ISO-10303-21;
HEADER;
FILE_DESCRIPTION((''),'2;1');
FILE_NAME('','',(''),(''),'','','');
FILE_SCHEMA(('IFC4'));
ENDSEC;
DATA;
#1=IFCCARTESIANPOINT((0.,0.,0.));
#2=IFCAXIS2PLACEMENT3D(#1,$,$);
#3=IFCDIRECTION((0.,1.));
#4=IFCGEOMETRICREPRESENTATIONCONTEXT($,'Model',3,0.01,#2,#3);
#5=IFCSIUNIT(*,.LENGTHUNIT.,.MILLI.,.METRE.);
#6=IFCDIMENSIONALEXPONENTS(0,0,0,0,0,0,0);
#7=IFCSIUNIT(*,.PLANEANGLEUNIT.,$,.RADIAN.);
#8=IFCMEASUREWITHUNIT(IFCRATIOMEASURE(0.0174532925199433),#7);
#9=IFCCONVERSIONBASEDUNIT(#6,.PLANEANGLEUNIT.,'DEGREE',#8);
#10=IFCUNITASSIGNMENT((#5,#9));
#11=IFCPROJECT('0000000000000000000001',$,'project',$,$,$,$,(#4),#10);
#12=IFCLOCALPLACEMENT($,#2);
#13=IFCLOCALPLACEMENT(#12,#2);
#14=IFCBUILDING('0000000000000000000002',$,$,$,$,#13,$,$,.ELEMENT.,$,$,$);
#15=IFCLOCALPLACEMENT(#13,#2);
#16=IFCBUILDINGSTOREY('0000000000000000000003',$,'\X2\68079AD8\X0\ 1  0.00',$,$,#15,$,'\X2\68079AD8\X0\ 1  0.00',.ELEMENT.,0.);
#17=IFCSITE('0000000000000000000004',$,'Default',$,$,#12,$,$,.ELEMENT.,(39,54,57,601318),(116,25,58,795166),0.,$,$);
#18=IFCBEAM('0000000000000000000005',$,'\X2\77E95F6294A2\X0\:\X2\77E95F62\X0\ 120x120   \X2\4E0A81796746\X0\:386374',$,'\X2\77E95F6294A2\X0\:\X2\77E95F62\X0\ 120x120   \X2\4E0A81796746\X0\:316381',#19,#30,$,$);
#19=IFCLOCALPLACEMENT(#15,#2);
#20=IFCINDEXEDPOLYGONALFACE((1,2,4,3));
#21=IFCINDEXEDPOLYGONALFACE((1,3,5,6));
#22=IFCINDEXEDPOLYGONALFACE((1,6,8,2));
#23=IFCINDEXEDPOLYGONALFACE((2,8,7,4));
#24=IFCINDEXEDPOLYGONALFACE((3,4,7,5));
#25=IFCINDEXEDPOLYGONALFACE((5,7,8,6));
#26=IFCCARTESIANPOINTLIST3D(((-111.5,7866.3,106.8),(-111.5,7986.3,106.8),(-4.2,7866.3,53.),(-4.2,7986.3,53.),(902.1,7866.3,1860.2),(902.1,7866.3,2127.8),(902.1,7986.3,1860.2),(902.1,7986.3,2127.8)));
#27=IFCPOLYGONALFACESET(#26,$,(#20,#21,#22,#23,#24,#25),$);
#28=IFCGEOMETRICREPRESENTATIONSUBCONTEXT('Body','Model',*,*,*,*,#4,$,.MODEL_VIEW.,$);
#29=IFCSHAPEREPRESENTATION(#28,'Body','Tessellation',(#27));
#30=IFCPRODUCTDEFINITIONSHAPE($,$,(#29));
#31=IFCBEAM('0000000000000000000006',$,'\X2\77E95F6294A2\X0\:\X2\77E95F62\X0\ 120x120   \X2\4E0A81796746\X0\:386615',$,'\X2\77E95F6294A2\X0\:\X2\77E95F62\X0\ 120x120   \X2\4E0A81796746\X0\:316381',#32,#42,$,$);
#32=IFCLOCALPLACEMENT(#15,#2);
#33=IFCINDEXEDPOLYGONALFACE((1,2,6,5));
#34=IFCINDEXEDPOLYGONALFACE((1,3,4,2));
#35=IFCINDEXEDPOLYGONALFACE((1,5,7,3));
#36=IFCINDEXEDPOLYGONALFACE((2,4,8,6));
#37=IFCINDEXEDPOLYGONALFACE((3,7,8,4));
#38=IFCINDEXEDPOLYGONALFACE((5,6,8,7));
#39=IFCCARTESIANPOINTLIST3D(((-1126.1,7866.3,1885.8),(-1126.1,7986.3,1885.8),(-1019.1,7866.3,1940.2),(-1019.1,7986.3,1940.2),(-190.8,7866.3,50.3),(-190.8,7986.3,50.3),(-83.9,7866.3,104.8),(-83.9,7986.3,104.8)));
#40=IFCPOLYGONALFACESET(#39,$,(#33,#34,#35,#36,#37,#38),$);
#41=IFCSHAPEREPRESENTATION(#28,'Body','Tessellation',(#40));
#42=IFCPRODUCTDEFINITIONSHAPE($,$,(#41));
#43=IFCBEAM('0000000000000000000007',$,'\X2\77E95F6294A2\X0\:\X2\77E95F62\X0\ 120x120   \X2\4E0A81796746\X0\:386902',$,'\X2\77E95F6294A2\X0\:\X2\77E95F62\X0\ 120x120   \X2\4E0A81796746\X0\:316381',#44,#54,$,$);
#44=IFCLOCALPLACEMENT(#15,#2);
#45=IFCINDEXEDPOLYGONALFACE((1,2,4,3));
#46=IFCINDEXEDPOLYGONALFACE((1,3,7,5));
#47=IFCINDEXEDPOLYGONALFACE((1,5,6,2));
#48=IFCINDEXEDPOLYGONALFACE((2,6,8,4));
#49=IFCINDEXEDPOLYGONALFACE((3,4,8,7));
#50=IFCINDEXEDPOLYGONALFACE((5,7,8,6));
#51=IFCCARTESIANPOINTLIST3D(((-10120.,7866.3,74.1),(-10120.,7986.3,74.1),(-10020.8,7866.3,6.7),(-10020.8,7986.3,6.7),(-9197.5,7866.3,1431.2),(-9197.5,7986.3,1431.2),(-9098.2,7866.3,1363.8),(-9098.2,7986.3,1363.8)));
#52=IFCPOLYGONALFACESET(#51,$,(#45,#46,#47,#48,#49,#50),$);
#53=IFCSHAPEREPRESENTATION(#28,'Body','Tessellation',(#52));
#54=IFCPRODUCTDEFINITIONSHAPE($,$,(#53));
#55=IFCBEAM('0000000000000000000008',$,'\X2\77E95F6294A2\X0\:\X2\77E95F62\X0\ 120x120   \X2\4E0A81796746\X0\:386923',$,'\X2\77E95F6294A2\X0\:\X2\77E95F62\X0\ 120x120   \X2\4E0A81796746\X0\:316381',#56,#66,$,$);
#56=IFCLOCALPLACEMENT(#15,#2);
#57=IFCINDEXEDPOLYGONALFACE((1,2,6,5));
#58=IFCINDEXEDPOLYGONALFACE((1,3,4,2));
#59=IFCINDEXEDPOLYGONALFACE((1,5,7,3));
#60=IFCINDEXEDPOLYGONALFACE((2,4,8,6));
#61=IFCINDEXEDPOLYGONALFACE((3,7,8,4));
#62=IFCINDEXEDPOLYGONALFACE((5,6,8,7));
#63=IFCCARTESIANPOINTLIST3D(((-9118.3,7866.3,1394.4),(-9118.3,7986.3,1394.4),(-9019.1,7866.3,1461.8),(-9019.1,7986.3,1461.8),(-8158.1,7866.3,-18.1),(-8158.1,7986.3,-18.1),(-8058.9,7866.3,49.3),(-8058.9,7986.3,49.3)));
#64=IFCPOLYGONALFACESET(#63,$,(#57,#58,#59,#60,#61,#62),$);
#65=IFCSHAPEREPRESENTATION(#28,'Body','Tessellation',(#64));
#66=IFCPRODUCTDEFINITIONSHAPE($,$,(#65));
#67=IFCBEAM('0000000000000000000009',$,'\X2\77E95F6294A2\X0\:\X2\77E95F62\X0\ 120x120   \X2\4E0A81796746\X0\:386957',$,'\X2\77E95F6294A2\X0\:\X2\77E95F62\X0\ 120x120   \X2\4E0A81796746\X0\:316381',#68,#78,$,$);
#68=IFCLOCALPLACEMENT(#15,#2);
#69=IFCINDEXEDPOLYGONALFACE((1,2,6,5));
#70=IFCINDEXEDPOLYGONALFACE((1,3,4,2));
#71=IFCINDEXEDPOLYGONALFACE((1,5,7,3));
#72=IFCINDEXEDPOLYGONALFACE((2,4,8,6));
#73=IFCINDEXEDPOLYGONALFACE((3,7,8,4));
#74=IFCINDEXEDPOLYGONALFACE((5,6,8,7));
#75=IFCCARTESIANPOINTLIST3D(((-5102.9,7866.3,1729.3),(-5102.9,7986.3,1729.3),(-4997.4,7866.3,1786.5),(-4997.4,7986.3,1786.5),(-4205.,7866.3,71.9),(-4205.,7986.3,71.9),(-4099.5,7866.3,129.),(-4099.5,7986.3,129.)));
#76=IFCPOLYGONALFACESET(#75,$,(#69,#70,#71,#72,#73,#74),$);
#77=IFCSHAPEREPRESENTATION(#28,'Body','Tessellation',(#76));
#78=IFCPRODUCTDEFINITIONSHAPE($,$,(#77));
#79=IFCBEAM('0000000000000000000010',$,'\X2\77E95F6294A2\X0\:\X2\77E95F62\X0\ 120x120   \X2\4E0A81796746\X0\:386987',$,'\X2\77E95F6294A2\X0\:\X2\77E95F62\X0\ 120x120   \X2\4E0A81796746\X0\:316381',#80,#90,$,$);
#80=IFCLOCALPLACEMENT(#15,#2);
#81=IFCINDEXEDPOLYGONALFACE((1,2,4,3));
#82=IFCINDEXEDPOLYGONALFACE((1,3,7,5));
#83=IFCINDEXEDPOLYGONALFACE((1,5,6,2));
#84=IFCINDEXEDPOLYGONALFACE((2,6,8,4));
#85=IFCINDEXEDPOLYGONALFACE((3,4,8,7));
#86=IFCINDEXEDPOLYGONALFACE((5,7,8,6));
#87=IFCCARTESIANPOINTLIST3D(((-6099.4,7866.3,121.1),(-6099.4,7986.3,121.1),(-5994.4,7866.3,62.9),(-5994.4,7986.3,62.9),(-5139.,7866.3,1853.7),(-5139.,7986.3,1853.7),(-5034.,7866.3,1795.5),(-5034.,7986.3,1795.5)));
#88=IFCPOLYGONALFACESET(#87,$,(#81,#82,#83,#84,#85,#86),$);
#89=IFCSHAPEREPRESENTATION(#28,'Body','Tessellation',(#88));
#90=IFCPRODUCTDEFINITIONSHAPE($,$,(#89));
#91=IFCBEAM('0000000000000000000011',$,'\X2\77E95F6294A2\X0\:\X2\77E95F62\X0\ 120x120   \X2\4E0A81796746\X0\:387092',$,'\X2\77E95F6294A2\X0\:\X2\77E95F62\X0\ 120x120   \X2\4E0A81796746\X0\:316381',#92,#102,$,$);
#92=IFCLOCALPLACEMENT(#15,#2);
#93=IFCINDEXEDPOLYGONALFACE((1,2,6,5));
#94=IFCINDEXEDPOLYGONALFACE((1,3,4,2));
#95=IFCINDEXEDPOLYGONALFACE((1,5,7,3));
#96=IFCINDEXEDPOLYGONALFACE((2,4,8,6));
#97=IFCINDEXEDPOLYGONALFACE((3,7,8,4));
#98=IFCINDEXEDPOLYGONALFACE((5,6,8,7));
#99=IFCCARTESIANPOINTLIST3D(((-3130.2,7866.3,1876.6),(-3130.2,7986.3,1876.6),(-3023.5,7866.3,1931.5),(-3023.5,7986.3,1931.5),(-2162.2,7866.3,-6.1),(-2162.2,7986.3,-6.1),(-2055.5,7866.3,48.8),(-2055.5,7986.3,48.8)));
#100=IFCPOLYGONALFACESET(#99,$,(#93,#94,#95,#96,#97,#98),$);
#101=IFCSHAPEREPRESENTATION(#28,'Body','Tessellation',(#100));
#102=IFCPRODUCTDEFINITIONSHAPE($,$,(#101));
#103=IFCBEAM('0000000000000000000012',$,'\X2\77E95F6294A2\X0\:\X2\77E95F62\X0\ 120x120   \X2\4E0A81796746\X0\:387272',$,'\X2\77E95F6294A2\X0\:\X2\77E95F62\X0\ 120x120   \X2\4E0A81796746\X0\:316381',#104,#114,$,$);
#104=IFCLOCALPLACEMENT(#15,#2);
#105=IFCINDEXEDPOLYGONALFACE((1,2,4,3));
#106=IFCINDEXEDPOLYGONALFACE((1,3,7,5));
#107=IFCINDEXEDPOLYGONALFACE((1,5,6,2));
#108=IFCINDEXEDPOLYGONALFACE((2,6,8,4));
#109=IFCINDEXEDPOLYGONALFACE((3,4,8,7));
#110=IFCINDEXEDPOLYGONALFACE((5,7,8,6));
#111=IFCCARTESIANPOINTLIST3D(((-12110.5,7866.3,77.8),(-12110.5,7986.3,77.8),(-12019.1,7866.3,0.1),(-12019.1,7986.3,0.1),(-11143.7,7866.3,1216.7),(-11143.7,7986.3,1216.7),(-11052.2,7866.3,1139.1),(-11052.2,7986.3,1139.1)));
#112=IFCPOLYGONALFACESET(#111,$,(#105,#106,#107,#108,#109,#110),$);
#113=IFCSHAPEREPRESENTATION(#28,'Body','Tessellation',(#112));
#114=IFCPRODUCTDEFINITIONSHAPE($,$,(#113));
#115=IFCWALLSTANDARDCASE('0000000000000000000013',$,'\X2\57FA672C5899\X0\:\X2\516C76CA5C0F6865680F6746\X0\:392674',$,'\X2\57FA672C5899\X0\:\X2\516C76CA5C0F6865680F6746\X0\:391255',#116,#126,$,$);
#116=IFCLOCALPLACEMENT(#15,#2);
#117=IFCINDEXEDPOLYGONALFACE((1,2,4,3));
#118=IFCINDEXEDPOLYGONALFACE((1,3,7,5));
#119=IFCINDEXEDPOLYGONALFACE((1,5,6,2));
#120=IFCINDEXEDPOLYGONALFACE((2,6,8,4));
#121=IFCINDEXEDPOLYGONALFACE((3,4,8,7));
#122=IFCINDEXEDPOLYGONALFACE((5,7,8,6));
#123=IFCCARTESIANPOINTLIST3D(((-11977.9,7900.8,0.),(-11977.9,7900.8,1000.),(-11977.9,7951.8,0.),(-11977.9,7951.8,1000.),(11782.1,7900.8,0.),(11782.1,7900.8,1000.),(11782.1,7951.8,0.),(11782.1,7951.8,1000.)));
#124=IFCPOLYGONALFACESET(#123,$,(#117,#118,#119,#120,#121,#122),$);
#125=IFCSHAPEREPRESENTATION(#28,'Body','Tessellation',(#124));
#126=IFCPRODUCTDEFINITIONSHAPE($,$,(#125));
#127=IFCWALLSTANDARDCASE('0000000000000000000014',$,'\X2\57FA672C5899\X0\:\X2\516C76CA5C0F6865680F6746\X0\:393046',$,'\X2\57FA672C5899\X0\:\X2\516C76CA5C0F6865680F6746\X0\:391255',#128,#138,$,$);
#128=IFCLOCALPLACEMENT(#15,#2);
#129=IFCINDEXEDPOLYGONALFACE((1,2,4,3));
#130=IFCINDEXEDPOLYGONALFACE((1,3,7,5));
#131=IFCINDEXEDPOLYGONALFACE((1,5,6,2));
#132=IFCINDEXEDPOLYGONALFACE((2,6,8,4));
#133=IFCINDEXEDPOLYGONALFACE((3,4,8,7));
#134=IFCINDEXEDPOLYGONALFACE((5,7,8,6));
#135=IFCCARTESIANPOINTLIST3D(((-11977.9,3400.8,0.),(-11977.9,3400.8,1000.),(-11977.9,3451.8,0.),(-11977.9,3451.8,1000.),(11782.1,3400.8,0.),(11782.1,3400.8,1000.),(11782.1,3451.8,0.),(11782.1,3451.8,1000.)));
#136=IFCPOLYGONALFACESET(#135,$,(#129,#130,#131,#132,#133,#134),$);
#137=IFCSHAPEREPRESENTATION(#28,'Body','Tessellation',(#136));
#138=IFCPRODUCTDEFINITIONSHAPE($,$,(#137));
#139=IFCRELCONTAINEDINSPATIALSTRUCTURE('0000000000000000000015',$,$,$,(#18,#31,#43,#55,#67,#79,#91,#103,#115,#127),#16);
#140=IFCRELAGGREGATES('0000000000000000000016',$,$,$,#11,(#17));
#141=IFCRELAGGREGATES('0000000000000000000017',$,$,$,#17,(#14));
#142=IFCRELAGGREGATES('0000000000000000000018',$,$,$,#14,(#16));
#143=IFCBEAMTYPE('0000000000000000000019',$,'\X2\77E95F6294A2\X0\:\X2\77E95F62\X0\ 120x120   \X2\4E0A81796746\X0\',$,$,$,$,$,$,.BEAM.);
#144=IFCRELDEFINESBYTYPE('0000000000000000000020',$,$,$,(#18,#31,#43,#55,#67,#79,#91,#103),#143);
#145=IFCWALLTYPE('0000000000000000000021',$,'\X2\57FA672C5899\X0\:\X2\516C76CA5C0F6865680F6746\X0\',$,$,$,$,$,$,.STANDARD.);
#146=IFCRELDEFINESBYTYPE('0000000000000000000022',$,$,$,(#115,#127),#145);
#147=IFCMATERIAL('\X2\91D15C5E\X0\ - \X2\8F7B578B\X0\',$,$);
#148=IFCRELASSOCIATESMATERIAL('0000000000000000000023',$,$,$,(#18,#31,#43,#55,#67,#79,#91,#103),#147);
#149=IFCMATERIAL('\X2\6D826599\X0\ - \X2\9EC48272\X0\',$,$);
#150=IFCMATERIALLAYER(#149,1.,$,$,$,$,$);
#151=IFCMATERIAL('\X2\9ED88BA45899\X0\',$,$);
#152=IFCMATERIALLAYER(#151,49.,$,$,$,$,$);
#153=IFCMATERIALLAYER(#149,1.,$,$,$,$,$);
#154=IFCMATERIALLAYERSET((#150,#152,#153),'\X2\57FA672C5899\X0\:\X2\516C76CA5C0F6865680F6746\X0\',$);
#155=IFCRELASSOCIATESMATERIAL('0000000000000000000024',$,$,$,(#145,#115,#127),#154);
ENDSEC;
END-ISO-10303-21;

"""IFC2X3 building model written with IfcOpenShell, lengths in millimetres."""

from ifc_helpers import new_model, entity, si_unit, converted_unit, direction, frame, frame_2d, origin, origin_2d_with_axis, place, context, subcontext, project, spatial, rectangle, extrude, clip, halfspace, material, layer, layer_set, layer_usage, type_object, element, save


model = new_model("IFC2X3")

# Units and contexts
model_context = context("Model", 3, precision=0.01, world=origin(), true_north=direction((0.0, 1.0)))
body_context = subcontext(model_context, "Body", "Model", "MODEL_VIEW")
ifc_project = project(units=[si_unit("LENGTHUNIT", "METRE", prefix="MILLI"), converted_unit("PLANEANGLEUNIT", "DEGREE", entity("IfcRatioMeasure", 0.0174532925199433), si_unit("PLANEANGLEUNIT", "RADIAN"), dimensions=[0, 0, 0, 0, 0, 0, 0])], contexts=[model_context])

# Site, building, storey
site_placement = place(None, origin())
site = spatial("IfcSite", under=ifc_project, at=site_placement, Name="Default", CompositionType="ELEMENT", RefLatitude=(39, 54, 57, 601318), RefLongitude=(116, 25, 58, 795166), RefElevation=0.0)
building_placement = place(site_placement, origin())
building = spatial("IfcBuilding", under=site, at=building_placement, CompositionType="ELEMENT")
storey_placement = place(building_placement, origin())
storey = spatial("IfcBuildingStorey", under=building, at=storey_placement, Name="标高 1  0.00", LongName="标高 1  0.00", CompositionType="ELEMENT", Elevation=0.0)

# Shared definitions
ifc_material_1 = material(Name="金属 - 轻型")

# Beams
beam_type_1 = type_object("IfcBeamType", Name="矩形钢:矩形 120x120   上腹杆", PredefinedType="BEAM")
beam_1_placement = place(storey_placement, frame((-97.9, 7926.3, 0.0), z_axis=(0.893889, 0.0, -0.448289), x_axis=(0.448289, 0.0, 0.893889)))
element("IfcBeam", 1, at=beam_1_placement, inside=storey, type_object=beam_type_1, material=ifc_material_1, Name="矩形钢:矩形 120x120   上腹杆:386374", ObjectType="矩形钢:矩形 120x120   上腹杆:316381", context=body_context, shape_type="Clipping", body=[
    clip(extrude(rectangle(XDim=120.0, YDim=120.0, at=frame_2d((0.0, 0.0), x_axis=(1.0, 0.0))), frame((89.4, 0.0, 0.0), z_axis=(1.0, 0.0, 0.0), x_axis=(0.0, 0.0, -1.0)), (0.0, 0.0, 1.0), 2261.0), halfspace(frame((2111.1, 0.0, 60.0), z_axis=(0.448289, 0.0, 0.893889), x_axis=(0.0, 1.0, 0.0)), False)),
])
beam_2_placement = place(storey_placement, frame((-97.9, 7926.3, 0.0), z_axis=(0.891007, 0.0, 0.45399), x_axis=(-0.45399, 0.0, 0.891007)))
element("IfcBeam", 2, at=beam_2_placement, inside=storey, type_object=beam_type_1, material=ifc_material_1, Name="矩形钢:矩形 120x120   上腹杆:386615", ObjectType="矩形钢:矩形 120x120   上腹杆:316381", context=body_context, shape_type="SweptSolid", body=[
    extrude(rectangle(XDim=120.0, YDim=120.0, at=frame_2d((0.0, 0.0), x_axis=(1.0, 0.0))), frame((87.0, 0.0, 0.0), z_axis=(1.0, 0.0, 0.0), x_axis=(0.0, 0.0, -1.0)), (0.0, 0.0, 1.0), 2060.0),
])
beam_3_placement = place(storey_placement, frame((-10097.9, 7926.3, 0.0), z_axis=(0.827, 0.0, -0.562202), x_axis=(0.562202, 0.0, 0.827)))
element("IfcBeam", 3, at=beam_3_placement, inside=storey, type_object=beam_type_1, material=ifc_material_1, Name="矩形钢:矩形 120x120   上腹杆:386902", ObjectType="矩形钢:矩形 120x120   上腹杆:316381", context=body_context, shape_type="SweptSolid", body=[
    extrude(rectangle(XDim=120.0, YDim=120.0, at=frame_2d((0.0, 0.0), x_axis=(1.0, 0.0))), frame((48.9, 0.0, 0.0), z_axis=(1.0, 0.0, 0.0), x_axis=(0.0, 0.0, -1.0)), (0.0, 0.0, 1.0), 1641.0),
])
beam_4_placement = place(storey_placement, frame((-8097.9, 7926.3, 0.0), z_axis=(0.827, 0.0, 0.562202), x_axis=(-0.562202, 0.0, 0.827)))
element("IfcBeam", 4, at=beam_4_placement, inside=storey, type_object=beam_type_1, material=ifc_material_1, Name="矩形钢:矩形 120x120   上腹杆:386923", ObjectType="矩形钢:矩形 120x120   上腹杆:316381", context=body_context, shape_type="SweptSolid", body=[
    extrude(rectangle(XDim=120.0, YDim=120.0, at=frame_2d((0.0, 0.0), x_axis=(1.0, 0.0))), frame((18.9, 0.0, 0.0), z_axis=(1.0, 0.0, 0.0), x_axis=(0.0, 0.0, -1.0)), (0.0, 0.0, 1.0), 1708.0),
])
beam_5_placement = place(storey_placement, frame((-4097.9, 7926.3, 0.0), z_axis=(0.879275, 0.0, 0.476314), x_axis=(-0.476314, 0.0, 0.879275)))
element("IfcBeam", 5, at=beam_5_placement, inside=storey, type_object=beam_type_1, material=ifc_material_1, Name="矩形钢:矩形 120x120   上腹杆:386957", ObjectType="矩形钢:矩形 120x120   上腹杆:316381", context=body_context, shape_type="SweptSolid", body=[
    extrude(rectangle(XDim=120.0, YDim=120.0, at=frame_2d((0.0, 0.0), x_axis=(1.0, 0.0))), frame((114.2, 0.0, 0.0), z_axis=(1.0, 0.0, 0.0), x_axis=(0.0, 0.0, -1.0)), (0.0, 0.0, 1.0), 1885.0),
])
beam_6_placement = place(storey_placement, frame((-6097.9, 7926.3, 0.0), z_axis=(0.87462, 0.0, -0.48481), x_axis=(0.48481, 0.0, 0.87462)))
element("IfcBeam", 6, at=beam_6_placement, inside=storey, type_object=beam_type_1, material=ifc_material_1, Name="矩形钢:矩形 120x120   上腹杆:386987", ObjectType="矩形钢:矩形 120x120   上腹杆:316381", context=body_context, shape_type="SweptSolid", body=[
    extrude(rectangle(XDim=120.0, YDim=120.0, at=frame_2d((0.0, 0.0), x_axis=(1.0, 0.0))), frame((105.2, 0.0, 0.0), z_axis=(1.0, 0.0, 0.0), x_axis=(0.0, 0.0, -1.0)), (0.0, 0.0, 1.0), 1981.0),
])
beam_7_placement = place(storey_placement, frame((-2097.9, 7926.3, 0.0), z_axis=(0.889341, 0.0, 0.457245), x_axis=(-0.457245, 0.0, 0.889341)))
element("IfcBeam", 7, at=beam_7_placement, inside=storey, type_object=beam_type_1, material=ifc_material_1, Name="矩形钢:矩形 120x120   上腹杆:387092", ObjectType="矩形钢:矩形 120x120   上腹杆:316381", context=body_context, shape_type="SweptSolid", body=[
    extrude(rectangle(XDim=120.0, YDim=120.0, at=frame_2d((0.0, 0.0), x_axis=(1.0, 0.0))), frame((24.0, 0.0, 0.0), z_axis=(1.0, 0.0, 0.0), x_axis=(0.0, 0.0, -1.0)), (0.0, 0.0, 1.0), 2117.0),
])
beam_8_placement = place(storey_placement, frame((-11097.9, 7926.3, 1178.0), z_axis=(0.762354, 0.0, -0.64716), x_axis=(-0.64716, 0.0, -0.762354)))
element("IfcBeam", 8, at=beam_8_placement, inside=storey, type_object=beam_type_1, material=ifc_material_1, Name="矩形钢:矩形 120x120   上腹杆:387272", ObjectType="矩形钢:矩形 120x120   上腹杆:316381", context=body_context, shape_type="SweptSolid", body=[
    extrude(rectangle(XDim=120.0, YDim=120.0, at=origin_2d_with_axis()), frame((0.1, 0.0, 0.0), z_axis=(1.0, 0.0, 0.0), x_axis=(0.0, 0.0, -1.0)), (0.0, 0.0, 1.0), 1494.0),
])

# Walls
ifc_material_2 = material(Name="涂料 - 黄色")
ifc_layer_1 = layer(ifc_material_2, 1.0)
ifc_material_3 = material(Name="默认墙")
ifc_layer_2 = layer(ifc_material_3, 49.0)
ifc_layer_3 = layer(ifc_material_2, 1.0)
ifc_layer_set = layer_set([ifc_layer_1, ifc_layer_2, ifc_layer_3], Name="基本墙:公益小桥栏杆")
ifc_layer_usage_1 = layer_usage(ifc_layer_set, "AXIS2", "NEGATIVE", 25.5)
wall_type = type_object("IfcWallType", Name="基本墙:公益小桥栏杆", PredefinedType="STANDARD", material=ifc_layer_set)
wall_1_placement = place(storey_placement, frame((-11977.9, 7926.3, 0.0)))
element("IfcWallStandardCase", 9, at=wall_1_placement, inside=storey, type_object=wall_type, material=ifc_layer_usage_1, Name="基本墙:公益小桥栏杆:392674", ObjectType="基本墙:公益小桥栏杆:391255", context=body_context, shape_type="SweptSolid", body=[
    extrude(rectangle(XDim=23760.0, YDim=51.0, at=frame_2d((11880.0, 0.0), x_axis=(-1.0, 0.0))), origin(), (0.0, 0.0, 1.0), 1000.0),
])
ifc_layer_usage_2 = layer_usage(ifc_layer_set, "AXIS2", "NEGATIVE", 25.5)
wall_2_placement = place(storey_placement, frame((-11977.9, 3426.3, 0.0)))
element("IfcWallStandardCase", 10, at=wall_2_placement, inside=storey, type_object=wall_type, material=ifc_layer_usage_2, Name="基本墙:公益小桥栏杆:393046", ObjectType="基本墙:公益小桥栏杆:391255", context=body_context, shape_type="SweptSolid", body=[
    extrude(rectangle(XDim=23760.0, YDim=51.0, at=frame_2d((11880.0, 0.0), x_axis=(-1.0, 0.0))), origin(), (0.0, 0.0, 1.0), 1000.0),
])

save(model, "model.ifc")
